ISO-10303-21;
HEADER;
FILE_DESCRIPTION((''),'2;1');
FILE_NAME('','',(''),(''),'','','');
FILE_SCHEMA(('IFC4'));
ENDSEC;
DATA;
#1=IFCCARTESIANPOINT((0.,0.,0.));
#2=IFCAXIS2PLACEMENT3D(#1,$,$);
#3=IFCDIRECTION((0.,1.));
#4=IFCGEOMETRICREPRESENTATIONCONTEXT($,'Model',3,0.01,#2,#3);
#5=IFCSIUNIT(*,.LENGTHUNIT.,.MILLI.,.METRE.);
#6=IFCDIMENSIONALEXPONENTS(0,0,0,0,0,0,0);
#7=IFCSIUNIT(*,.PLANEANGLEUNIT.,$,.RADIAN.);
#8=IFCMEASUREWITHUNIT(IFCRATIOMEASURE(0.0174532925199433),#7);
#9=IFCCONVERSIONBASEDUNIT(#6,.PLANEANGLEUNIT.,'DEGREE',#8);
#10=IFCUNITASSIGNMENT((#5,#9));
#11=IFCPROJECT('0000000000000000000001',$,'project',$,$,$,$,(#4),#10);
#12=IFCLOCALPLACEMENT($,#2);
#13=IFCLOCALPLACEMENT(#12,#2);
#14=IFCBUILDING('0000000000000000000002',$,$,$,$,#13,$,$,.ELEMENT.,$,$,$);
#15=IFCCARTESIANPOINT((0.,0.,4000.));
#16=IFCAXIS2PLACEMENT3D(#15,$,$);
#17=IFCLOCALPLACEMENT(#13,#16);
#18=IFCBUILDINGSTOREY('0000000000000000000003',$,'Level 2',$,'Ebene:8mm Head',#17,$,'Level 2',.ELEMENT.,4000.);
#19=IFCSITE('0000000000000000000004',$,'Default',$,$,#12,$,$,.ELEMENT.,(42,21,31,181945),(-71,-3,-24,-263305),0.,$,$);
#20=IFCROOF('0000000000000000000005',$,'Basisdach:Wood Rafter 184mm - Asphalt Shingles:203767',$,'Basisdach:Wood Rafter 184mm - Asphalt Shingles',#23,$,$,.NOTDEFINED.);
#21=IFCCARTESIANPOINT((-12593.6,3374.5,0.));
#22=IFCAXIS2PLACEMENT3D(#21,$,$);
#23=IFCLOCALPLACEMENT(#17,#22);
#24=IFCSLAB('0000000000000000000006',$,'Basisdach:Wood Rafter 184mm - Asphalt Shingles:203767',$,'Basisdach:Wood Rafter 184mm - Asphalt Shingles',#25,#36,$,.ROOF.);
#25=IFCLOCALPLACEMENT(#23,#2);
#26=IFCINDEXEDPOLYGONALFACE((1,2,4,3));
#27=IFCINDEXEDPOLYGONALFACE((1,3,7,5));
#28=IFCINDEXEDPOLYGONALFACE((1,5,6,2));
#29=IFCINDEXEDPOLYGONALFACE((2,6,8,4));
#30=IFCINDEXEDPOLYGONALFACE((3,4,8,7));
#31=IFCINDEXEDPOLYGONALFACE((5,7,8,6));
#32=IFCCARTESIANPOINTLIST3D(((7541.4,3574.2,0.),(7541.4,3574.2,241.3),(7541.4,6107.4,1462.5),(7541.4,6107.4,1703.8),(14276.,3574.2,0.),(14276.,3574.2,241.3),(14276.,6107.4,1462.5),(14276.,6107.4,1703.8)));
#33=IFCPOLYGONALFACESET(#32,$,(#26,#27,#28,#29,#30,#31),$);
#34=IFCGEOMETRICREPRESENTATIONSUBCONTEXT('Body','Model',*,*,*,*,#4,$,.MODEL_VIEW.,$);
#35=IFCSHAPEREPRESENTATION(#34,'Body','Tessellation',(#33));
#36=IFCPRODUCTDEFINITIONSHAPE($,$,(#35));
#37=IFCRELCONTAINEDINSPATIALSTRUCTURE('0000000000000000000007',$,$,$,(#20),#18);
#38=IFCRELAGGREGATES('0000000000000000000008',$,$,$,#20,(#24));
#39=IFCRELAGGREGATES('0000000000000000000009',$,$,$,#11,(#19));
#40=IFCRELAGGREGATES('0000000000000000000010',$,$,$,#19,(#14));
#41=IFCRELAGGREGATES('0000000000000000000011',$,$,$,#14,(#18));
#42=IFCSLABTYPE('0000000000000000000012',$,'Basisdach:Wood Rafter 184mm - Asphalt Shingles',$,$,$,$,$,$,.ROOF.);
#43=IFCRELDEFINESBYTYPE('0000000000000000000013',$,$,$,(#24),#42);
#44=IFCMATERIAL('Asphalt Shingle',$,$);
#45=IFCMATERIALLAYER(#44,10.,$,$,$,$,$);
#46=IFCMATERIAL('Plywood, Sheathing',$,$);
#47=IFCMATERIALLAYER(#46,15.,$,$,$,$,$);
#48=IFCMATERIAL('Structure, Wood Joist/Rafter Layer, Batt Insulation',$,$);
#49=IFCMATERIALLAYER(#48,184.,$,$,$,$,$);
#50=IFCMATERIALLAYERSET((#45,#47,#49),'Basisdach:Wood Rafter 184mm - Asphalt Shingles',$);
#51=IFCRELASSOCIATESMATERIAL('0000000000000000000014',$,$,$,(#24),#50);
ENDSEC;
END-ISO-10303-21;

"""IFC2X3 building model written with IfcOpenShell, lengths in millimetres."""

from ifc_helpers import new_model, entity, si_unit, converted_unit, direction, frame, frame_2d, origin, place, context, subcontext, project, spatial, rectangle, extrude, material, layer, layer_set, type_object, element, aggregate, save


model = new_model("IFC2X3")

# Units and contexts
model_context = context("Model", 3, precision=0.01, world=origin(), true_north=direction((0.0, 1.0)))
body_context = subcontext(model_context, "Body", "Model", "MODEL_VIEW")
ifc_project = project(units=[si_unit("LENGTHUNIT", "METRE", prefix="MILLI"), converted_unit("PLANEANGLEUNIT", "DEGREE", entity("IfcRatioMeasure", 0.0174532925199433), si_unit("PLANEANGLEUNIT", "RADIAN"), dimensions=[0, 0, 0, 0, 0, 0, 0])], contexts=[model_context])

# Site, building, storey
site_placement = place(None, origin())
site = spatial("IfcSite", under=ifc_project, at=site_placement, Name="Default", CompositionType="ELEMENT", RefLatitude=(42, 21, 31, 181945), RefLongitude=(-71, -3, -24, -263305), RefElevation=0.0)
building_placement = place(site_placement, origin())
building = spatial("IfcBuilding", under=site, at=building_placement, CompositionType="ELEMENT")
storey_placement = place(building_placement, frame((0.0, 0.0, 4000.0)))
storey = spatial("IfcBuildingStorey", under=building, at=storey_placement, Name="Level 2", ObjectType="Ebene:8mm Head", LongName="Level 2", CompositionType="ELEMENT", Elevation=4000.0)

# Roof, slab
roof_placement = place(storey_placement, frame((-12593.6, 3374.5, 0.0)))
roof = element("IfcRoof", 1, at=roof_placement, inside=storey, Name="Basisdach:Wood Rafter 184mm - Asphalt Shingles:203767", ObjectType="Basisdach:Wood Rafter 184mm - Asphalt Shingles", ShapeType="NOTDEFINED")
ifc_material_1 = material(Name="Asphalt Shingle")
ifc_layer_1 = layer(ifc_material_1, 10.0)
ifc_material_2 = material(Name="Plywood, Sheathing")
ifc_layer_2 = layer(ifc_material_2, 15.0)
ifc_material_3 = material(Name="Structure, Wood Joist/Rafter Layer, Batt Insulation")
ifc_layer_3 = layer(ifc_material_3, 184.0)
ifc_layer_set_1 = layer_set([ifc_layer_1, ifc_layer_2, ifc_layer_3], Name="Basisdach:Wood Rafter 184mm - Asphalt Shingles")
slab_type_1 = type_object("IfcSlabType", Name="Basisdach:Wood Rafter 184mm - Asphalt Shingles", PredefinedType="ROOF")
slab_1_placement = place(roof_placement, origin())
slab_1 = element("IfcSlab", 2, at=slab_1_placement, type_object=slab_type_1, material=ifc_layer_set_1, Name="Basisdach:Wood Rafter 184mm - Asphalt Shingles:203767", ObjectType="Basisdach:Wood Rafter 184mm - Asphalt Shingles", PredefinedType="ROOF", context=body_context, shape_type="SweptSolid", body=[
    extrude(rectangle(XDim=2925.0, YDim=6734.6, at=frame_2d((0.0, 0.0), x_axis=(0.0, 1.0))), frame((10908.7, 4840.8, 731.3), z_axis=(0.0, -0.5, 0.866025), x_axis=(1.0, 0.0, 0.0)), (0.0, 0.5, 0.866025), 241.3),
])
aggregate(roof, [slab_1])

save(model, "model.ifc")
